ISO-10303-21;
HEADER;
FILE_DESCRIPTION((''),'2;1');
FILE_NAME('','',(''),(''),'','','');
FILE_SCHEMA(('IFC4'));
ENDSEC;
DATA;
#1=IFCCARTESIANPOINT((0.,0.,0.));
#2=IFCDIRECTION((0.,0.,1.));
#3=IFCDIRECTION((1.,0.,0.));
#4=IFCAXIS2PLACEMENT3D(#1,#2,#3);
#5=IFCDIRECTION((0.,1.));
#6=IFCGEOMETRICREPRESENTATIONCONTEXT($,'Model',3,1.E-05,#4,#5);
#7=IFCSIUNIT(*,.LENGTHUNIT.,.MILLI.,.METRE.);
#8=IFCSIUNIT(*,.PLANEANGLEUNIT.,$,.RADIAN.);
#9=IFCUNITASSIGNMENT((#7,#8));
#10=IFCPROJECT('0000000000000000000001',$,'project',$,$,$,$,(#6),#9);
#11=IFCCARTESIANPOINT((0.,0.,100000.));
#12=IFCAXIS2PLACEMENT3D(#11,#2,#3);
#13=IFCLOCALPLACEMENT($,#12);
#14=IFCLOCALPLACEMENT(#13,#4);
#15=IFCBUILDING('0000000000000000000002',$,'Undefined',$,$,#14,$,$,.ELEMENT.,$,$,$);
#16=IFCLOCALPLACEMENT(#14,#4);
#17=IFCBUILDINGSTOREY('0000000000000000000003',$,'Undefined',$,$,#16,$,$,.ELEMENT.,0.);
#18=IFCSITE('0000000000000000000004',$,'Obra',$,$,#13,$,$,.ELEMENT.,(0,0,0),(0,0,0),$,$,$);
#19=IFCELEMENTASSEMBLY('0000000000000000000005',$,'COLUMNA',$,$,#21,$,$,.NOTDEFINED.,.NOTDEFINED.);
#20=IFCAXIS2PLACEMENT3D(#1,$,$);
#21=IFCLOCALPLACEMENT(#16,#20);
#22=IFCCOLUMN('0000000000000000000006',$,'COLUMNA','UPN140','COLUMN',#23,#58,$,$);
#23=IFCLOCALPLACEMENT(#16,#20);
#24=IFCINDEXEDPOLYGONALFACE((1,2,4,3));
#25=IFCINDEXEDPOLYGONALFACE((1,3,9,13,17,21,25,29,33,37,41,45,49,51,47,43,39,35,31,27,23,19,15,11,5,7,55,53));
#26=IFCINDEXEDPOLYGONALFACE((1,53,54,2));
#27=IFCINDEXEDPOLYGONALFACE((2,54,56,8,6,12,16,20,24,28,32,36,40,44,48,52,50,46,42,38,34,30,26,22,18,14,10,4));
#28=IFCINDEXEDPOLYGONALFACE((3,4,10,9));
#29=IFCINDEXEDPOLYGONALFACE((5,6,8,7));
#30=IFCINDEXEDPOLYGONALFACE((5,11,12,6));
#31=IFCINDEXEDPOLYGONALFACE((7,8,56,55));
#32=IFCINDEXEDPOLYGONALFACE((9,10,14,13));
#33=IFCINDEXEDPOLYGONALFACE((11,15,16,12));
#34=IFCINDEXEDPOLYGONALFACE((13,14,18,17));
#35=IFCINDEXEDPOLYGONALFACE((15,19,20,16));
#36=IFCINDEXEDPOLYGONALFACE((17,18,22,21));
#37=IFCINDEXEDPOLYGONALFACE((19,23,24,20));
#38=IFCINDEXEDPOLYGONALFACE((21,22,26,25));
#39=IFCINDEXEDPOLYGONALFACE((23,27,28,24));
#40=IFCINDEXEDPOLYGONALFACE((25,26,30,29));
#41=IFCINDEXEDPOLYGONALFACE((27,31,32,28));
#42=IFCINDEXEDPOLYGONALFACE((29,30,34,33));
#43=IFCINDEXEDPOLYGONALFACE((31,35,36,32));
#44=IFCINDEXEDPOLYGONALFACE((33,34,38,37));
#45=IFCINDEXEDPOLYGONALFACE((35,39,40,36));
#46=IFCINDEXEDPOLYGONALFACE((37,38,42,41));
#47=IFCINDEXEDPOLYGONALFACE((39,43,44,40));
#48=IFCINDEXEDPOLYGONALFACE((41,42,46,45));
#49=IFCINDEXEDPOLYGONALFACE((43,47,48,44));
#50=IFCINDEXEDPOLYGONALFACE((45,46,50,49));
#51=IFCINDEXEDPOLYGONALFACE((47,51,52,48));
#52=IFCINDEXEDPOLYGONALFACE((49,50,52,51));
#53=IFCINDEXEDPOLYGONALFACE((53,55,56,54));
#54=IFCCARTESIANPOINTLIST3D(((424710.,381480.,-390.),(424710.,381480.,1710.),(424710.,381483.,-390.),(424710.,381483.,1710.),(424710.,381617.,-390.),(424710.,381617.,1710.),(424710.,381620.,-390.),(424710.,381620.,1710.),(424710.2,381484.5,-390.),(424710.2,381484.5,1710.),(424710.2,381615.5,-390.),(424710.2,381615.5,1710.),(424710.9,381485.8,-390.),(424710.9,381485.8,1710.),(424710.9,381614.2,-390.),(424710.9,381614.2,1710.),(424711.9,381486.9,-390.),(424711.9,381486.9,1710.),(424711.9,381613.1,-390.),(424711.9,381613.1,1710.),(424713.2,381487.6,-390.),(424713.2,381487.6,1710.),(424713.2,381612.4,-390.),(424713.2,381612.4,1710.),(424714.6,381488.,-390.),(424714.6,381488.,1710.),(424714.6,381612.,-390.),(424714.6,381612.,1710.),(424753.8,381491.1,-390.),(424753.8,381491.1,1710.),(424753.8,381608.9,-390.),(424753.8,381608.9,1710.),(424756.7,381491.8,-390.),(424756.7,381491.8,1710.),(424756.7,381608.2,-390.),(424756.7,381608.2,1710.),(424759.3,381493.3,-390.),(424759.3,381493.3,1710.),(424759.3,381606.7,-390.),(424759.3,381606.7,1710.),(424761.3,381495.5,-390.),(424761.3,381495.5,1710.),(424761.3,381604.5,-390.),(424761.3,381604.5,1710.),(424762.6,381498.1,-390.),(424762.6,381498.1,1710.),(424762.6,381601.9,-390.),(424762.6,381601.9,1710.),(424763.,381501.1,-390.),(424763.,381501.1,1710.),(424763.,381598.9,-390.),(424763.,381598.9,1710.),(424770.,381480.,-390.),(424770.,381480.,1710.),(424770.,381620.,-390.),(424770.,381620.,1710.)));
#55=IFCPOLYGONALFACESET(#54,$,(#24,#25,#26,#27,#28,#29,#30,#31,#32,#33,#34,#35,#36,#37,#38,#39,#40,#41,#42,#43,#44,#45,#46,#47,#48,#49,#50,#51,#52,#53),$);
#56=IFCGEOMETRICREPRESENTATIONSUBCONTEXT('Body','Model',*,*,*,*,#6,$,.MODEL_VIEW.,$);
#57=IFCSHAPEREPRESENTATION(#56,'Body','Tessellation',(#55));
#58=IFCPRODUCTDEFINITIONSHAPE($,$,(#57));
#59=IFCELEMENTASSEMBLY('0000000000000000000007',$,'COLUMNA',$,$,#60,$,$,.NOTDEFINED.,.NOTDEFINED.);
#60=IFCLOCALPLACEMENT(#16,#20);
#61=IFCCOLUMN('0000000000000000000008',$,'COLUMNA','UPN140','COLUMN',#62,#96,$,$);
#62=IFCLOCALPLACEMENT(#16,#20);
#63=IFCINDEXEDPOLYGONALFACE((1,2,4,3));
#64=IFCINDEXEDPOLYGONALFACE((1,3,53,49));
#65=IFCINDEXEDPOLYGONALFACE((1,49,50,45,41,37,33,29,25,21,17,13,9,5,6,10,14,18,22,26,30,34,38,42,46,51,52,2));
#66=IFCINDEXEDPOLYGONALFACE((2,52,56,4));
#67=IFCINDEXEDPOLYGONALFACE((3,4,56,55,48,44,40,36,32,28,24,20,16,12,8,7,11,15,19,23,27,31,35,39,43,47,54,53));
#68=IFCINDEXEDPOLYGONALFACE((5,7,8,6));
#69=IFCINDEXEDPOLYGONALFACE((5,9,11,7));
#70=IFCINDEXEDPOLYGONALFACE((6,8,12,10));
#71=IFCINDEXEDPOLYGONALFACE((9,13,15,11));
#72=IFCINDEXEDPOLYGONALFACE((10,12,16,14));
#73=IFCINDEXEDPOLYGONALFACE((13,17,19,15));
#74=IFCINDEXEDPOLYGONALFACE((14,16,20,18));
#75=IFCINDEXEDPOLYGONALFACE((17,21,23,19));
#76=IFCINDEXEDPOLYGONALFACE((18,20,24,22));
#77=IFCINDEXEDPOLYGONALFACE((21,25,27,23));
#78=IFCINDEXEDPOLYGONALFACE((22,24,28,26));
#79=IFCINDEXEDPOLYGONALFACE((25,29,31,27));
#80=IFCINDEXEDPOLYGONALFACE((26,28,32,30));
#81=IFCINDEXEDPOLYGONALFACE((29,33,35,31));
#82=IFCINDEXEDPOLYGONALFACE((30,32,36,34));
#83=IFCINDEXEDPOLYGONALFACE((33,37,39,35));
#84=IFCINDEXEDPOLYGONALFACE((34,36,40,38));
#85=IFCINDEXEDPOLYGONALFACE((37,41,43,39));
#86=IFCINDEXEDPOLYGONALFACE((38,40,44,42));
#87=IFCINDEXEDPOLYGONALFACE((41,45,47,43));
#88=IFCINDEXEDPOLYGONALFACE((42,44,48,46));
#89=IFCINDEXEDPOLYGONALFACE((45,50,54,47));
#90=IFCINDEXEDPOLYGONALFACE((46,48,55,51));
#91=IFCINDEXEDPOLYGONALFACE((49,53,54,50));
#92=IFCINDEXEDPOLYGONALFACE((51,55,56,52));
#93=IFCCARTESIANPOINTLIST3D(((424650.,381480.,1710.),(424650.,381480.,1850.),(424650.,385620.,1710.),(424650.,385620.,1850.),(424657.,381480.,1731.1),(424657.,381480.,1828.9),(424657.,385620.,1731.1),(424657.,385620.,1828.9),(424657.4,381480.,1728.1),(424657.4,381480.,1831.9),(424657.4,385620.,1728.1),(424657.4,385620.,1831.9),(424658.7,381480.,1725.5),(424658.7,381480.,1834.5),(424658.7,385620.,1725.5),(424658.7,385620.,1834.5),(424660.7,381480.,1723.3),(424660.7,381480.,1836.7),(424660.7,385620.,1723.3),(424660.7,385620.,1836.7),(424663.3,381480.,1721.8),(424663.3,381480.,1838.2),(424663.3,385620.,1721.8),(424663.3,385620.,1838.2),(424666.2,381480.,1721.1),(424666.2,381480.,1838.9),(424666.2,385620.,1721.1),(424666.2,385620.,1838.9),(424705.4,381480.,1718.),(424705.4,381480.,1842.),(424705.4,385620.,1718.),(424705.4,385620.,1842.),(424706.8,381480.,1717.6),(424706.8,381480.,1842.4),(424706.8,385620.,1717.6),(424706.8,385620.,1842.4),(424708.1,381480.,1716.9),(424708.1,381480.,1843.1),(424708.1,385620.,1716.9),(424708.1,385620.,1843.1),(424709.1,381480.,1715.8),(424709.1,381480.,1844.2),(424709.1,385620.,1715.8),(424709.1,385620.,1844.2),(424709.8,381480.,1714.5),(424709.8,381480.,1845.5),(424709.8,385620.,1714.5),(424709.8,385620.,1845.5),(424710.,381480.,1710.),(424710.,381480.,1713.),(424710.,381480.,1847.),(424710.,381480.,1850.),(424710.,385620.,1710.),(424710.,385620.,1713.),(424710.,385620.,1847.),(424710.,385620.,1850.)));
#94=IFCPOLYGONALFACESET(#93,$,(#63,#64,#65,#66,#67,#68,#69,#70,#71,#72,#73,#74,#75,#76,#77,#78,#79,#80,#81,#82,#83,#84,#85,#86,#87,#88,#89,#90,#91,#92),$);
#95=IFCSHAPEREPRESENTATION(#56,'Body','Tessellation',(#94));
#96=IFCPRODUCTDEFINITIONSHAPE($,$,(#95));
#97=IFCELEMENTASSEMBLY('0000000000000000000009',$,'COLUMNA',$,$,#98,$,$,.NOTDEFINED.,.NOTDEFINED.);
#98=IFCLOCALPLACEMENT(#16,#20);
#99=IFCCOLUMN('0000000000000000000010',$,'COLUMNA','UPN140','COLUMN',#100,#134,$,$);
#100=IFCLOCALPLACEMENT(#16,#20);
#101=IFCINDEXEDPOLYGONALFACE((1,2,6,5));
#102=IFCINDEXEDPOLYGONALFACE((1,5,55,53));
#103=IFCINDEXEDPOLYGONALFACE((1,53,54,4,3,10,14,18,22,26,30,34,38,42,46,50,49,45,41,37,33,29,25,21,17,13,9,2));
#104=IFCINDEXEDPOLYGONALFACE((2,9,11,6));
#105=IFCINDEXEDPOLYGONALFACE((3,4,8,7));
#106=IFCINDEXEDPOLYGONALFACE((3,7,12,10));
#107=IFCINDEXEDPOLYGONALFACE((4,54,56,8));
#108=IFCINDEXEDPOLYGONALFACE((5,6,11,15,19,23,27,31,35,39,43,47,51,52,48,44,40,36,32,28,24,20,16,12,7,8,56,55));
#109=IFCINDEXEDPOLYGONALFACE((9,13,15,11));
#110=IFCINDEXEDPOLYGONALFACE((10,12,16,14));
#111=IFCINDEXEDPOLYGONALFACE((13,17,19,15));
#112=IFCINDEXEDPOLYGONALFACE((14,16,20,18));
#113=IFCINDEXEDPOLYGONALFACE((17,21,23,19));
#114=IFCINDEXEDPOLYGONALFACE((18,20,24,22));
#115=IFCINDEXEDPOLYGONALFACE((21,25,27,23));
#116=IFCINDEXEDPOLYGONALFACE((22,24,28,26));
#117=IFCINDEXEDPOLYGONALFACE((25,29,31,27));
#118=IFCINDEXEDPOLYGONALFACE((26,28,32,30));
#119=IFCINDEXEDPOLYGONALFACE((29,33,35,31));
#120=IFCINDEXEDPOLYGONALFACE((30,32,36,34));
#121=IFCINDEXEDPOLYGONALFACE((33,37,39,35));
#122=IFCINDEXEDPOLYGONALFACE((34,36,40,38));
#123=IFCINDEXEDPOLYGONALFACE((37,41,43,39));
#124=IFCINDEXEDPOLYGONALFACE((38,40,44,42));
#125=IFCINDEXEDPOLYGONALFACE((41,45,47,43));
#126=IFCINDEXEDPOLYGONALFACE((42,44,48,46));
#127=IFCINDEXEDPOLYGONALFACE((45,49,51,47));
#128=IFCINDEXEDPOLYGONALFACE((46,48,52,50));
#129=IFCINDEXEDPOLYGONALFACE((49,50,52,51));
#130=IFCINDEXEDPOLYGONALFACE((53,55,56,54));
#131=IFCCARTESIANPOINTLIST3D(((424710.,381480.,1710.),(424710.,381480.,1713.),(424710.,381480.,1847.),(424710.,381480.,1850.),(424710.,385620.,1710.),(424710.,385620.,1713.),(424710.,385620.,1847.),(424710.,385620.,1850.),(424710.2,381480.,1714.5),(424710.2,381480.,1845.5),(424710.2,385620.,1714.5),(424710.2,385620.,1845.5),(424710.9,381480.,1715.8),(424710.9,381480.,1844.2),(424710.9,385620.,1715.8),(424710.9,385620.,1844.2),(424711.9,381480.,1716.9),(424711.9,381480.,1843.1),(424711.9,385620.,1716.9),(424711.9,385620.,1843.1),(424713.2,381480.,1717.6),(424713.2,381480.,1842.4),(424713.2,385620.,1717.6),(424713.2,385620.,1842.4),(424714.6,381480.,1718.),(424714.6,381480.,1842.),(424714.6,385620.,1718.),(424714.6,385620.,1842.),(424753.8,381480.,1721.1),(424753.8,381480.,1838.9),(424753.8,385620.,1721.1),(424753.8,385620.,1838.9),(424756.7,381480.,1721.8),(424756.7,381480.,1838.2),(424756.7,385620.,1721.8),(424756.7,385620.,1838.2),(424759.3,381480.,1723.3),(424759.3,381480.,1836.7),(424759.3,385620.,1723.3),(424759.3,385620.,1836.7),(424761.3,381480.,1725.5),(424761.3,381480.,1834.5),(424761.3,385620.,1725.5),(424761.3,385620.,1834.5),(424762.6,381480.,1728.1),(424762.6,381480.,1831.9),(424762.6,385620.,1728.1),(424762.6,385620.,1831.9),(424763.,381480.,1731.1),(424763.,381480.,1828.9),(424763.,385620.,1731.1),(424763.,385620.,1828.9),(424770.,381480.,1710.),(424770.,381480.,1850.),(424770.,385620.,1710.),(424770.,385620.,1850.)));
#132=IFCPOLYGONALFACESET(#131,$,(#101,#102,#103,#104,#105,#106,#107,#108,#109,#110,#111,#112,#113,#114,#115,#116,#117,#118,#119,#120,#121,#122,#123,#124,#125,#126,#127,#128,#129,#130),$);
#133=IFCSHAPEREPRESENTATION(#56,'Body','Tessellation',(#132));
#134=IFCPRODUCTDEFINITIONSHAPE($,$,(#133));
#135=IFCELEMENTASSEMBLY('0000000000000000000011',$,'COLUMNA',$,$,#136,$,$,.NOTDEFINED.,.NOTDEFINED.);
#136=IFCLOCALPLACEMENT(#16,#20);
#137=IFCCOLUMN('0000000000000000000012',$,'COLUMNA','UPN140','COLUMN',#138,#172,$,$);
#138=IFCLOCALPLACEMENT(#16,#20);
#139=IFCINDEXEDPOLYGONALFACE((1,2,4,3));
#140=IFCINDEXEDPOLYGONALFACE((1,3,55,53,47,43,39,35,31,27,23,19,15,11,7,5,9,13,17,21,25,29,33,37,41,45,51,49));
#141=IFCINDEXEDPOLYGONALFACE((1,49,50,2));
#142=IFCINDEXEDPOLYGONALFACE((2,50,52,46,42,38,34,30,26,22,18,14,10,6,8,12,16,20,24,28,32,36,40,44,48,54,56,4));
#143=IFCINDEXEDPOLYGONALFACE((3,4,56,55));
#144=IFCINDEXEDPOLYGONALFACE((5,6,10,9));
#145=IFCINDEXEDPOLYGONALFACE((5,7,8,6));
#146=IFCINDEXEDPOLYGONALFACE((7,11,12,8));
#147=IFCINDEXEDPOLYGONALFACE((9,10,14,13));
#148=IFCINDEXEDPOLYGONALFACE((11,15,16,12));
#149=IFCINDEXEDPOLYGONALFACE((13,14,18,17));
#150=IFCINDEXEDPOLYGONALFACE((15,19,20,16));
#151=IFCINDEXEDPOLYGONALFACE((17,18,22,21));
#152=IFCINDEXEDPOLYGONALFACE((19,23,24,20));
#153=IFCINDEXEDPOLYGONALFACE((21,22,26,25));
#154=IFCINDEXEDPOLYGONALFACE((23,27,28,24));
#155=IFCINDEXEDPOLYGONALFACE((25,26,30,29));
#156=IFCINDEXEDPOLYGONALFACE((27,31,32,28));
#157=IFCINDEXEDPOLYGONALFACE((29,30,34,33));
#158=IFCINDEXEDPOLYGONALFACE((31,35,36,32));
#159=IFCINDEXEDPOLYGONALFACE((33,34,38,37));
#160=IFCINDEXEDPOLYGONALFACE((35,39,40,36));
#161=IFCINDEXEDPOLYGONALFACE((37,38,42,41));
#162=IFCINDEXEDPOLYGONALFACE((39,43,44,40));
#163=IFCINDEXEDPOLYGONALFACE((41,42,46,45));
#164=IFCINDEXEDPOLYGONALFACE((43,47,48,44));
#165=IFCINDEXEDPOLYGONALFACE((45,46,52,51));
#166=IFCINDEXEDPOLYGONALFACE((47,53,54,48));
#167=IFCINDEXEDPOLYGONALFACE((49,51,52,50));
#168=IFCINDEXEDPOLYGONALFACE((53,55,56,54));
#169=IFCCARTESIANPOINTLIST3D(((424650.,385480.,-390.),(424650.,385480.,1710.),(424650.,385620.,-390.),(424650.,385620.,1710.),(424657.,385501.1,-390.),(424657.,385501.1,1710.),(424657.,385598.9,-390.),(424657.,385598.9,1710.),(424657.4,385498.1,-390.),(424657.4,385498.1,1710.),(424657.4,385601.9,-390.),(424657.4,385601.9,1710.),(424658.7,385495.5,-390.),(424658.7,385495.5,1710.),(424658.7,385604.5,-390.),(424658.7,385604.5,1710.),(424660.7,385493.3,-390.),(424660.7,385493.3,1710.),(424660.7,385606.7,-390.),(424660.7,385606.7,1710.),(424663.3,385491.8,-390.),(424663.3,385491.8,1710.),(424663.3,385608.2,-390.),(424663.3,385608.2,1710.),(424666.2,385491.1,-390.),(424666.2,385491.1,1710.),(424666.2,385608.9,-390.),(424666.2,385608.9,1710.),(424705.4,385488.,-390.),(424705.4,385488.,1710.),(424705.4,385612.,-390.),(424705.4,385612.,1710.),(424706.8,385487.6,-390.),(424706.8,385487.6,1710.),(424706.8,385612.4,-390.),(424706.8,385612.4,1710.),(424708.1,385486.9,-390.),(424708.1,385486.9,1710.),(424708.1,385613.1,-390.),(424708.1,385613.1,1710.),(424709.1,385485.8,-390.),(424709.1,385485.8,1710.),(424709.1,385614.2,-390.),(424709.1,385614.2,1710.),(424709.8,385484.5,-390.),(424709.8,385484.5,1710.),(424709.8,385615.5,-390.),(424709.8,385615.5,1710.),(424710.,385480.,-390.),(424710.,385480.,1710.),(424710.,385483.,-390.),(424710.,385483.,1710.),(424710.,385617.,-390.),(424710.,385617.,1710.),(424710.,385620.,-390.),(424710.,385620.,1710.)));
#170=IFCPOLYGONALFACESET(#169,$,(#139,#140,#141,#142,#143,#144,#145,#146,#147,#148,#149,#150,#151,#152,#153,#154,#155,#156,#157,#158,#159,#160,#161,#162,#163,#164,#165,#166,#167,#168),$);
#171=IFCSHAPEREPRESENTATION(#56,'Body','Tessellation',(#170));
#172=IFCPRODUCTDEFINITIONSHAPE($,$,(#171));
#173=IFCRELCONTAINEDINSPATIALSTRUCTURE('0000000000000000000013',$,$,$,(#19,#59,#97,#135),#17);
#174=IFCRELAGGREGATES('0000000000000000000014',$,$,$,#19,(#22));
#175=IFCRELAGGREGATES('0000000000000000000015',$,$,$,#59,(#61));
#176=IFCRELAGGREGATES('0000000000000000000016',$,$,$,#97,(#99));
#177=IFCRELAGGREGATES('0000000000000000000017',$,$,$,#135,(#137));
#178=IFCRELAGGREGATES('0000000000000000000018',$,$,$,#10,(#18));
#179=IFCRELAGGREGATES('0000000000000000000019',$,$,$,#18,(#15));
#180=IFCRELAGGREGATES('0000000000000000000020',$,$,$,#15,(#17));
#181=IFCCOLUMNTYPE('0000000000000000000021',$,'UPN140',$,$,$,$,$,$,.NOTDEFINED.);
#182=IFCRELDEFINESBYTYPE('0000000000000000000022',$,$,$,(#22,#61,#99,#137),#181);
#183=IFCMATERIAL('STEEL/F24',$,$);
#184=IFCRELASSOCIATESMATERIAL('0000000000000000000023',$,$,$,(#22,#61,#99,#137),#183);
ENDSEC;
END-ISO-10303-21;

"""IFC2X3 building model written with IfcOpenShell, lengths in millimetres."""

from ifc_helpers import new_model, si_unit, direction, frame, origin_with_axes, origin_2d_with_axis, place, context, subcontext, project, spatial, u_section, extrude, material, type_object, element, aggregate, save


model = new_model("IFC2X3")

# Units and contexts
model_context = context("Model", 3, precision=1e-05, world=origin_with_axes(), true_north=direction((0.0, 1.0)))
body_context = subcontext(model_context, "Body", "Model", "MODEL_VIEW")
ifc_project = project(units=[si_unit("LENGTHUNIT", "METRE", prefix="MILLI"), si_unit("PLANEANGLEUNIT", "RADIAN")], contexts=[model_context])

# Site, building, storey
site_placement = place(None, frame((0.0, 0.0, 100000.0), z_axis=(0.0, 0.0, 1.0), x_axis=(1.0, 0.0, 0.0)))
site = spatial("IfcSite", under=ifc_project, at=site_placement, Name="Obra", CompositionType="ELEMENT", RefLatitude=(0, 0, 0), RefLongitude=(0, 0, 0))
building_placement = place(site_placement, origin_with_axes())
building = spatial("IfcBuilding", under=site, at=building_placement, Name="Undefined", CompositionType="ELEMENT")
storey_placement = place(building_placement, origin_with_axes())
storey = spatial("IfcBuildingStorey", under=building, at=storey_placement, Name="Undefined", CompositionType="ELEMENT", Elevation=0.0)

# Element assemblies, columns
ifc_material_1 = material(Name="STEEL/F24")
column_type_1 = type_object("IfcColumnType", Name="UPN140", PredefinedType="NOTDEFINED")
assembly_1_placement = place(storey_placement, origin_with_axes())
assembly_1 = element("IfcElementAssembly", 1, at=assembly_1_placement, inside=storey, Name="COLUMNA", AssemblyPlace="NOTDEFINED", PredefinedType="NOTDEFINED")
column_1_placement = place(assembly_1_placement, frame((424740.0, 381550.0, 1710.0), z_axis=(0.0, 0.0, -1.0), x_axis=(0.0, -1.0, 0.0)))
column_1 = element("IfcColumn", 2, at=column_1_placement, type_object=column_type_1, material=ifc_material_1, Name="COLUMNA", Description="UPN140", ObjectType="COLUMN", context=body_context, shape_type="SweptSolid", body=[
    extrude(u_section(Depth=140.0, FlangeWidth=60.0, WebThickness=7.0, FlangeThickness=10.0, FilletRadius=10.0, EdgeRadius=5.0, FlangeSlope=0.07983, at=origin_2d_with_axis()), frame((0.0, 0.0, 2100.0), z_axis=(0.0, 0.0, -1.0), x_axis=(0.0, 1.0, 0.0)), (0.0, 0.0, 1.0), 2100.0),
])
aggregate(assembly_1, [column_1])
assembly_2_placement = place(storey_placement, origin_with_axes())
assembly_2 = element("IfcElementAssembly", 3, at=assembly_2_placement, inside=storey, Name="COLUMNA", AssemblyPlace="NOTDEFINED", PredefinedType="NOTDEFINED")
column_2_placement = place(assembly_2_placement, frame((424680.0, 385620.0, 1780.0), z_axis=(0.0, -1.0, 0.0), x_axis=(0.0, 0.0, -1.0)))
column_2 = element("IfcColumn", 4, at=column_2_placement, type_object=column_type_1, material=ifc_material_1, Name="COLUMNA", Description="UPN140", ObjectType="COLUMN", context=body_context, shape_type="SweptSolid", body=[
    extrude(u_section(Depth=140.0, FlangeWidth=60.0, WebThickness=7.0, FlangeThickness=10.0, FilletRadius=10.0, EdgeRadius=5.0, FlangeSlope=0.07983, at=origin_2d_with_axis()), frame((0.0, 0.0, 4140.0), z_axis=(0.0, 0.0, -1.0), x_axis=(0.0, 1.0, 0.0)), (0.0, 0.0, 1.0), 4140.0),
])
aggregate(assembly_2, [column_2])
assembly_3_placement = place(storey_placement, origin_with_axes())
assembly_3 = element("IfcElementAssembly", 5, at=assembly_3_placement, inside=storey, Name="COLUMNA", AssemblyPlace="NOTDEFINED", PredefinedType="NOTDEFINED")
column_3_placement = place(assembly_3_placement, frame((424740.0, 385620.0, 1780.0), z_axis=(0.0, -1.0, 0.0), x_axis=(0.0, 0.0, 1.0)))
column_3 = element("IfcColumn", 6, at=column_3_placement, type_object=column_type_1, material=ifc_material_1, Name="COLUMNA", Description="UPN140", ObjectType="COLUMN", context=body_context, shape_type="SweptSolid", body=[
    extrude(u_section(Depth=140.0, FlangeWidth=60.0, WebThickness=7.0, FlangeThickness=10.0, FilletRadius=10.0, EdgeRadius=5.0, FlangeSlope=0.07983, at=origin_2d_with_axis()), frame((0.0, 0.0, 4140.0), z_axis=(0.0, 0.0, -1.0), x_axis=(0.0, 1.0, 0.0)), (0.0, 0.0, 1.0), 4140.0),
])
aggregate(assembly_3, [column_3])
assembly_4_placement = place(storey_placement, origin_with_axes())
assembly_4 = element("IfcElementAssembly", 7, at=assembly_4_placement, inside=storey, Name="COLUMNA", AssemblyPlace="NOTDEFINED", PredefinedType="NOTDEFINED")
column_4_placement = place(assembly_4_placement, frame((424680.0, 385550.0, -390.0), z_axis=(0.0, 0.0, 1.0), x_axis=(0.0, -1.0, 0.0)))
column_4 = element("IfcColumn", 8, at=column_4_placement, type_object=column_type_1, material=ifc_material_1, Name="COLUMNA", Description="UPN140", ObjectType="COLUMN", context=body_context, shape_type="SweptSolid", body=[
    extrude(u_section(Depth=140.0, FlangeWidth=60.0, WebThickness=7.0, FlangeThickness=10.0, FilletRadius=10.0, EdgeRadius=5.0, FlangeSlope=0.07983, at=origin_2d_with_axis()), frame((0.0, 0.0, 2100.0), z_axis=(0.0, 0.0, -1.0), x_axis=(0.0, 1.0, 0.0)), (0.0, 0.0, 1.0), 2100.0),
])
aggregate(assembly_4, [column_4])

save(model, "model.ifc")
